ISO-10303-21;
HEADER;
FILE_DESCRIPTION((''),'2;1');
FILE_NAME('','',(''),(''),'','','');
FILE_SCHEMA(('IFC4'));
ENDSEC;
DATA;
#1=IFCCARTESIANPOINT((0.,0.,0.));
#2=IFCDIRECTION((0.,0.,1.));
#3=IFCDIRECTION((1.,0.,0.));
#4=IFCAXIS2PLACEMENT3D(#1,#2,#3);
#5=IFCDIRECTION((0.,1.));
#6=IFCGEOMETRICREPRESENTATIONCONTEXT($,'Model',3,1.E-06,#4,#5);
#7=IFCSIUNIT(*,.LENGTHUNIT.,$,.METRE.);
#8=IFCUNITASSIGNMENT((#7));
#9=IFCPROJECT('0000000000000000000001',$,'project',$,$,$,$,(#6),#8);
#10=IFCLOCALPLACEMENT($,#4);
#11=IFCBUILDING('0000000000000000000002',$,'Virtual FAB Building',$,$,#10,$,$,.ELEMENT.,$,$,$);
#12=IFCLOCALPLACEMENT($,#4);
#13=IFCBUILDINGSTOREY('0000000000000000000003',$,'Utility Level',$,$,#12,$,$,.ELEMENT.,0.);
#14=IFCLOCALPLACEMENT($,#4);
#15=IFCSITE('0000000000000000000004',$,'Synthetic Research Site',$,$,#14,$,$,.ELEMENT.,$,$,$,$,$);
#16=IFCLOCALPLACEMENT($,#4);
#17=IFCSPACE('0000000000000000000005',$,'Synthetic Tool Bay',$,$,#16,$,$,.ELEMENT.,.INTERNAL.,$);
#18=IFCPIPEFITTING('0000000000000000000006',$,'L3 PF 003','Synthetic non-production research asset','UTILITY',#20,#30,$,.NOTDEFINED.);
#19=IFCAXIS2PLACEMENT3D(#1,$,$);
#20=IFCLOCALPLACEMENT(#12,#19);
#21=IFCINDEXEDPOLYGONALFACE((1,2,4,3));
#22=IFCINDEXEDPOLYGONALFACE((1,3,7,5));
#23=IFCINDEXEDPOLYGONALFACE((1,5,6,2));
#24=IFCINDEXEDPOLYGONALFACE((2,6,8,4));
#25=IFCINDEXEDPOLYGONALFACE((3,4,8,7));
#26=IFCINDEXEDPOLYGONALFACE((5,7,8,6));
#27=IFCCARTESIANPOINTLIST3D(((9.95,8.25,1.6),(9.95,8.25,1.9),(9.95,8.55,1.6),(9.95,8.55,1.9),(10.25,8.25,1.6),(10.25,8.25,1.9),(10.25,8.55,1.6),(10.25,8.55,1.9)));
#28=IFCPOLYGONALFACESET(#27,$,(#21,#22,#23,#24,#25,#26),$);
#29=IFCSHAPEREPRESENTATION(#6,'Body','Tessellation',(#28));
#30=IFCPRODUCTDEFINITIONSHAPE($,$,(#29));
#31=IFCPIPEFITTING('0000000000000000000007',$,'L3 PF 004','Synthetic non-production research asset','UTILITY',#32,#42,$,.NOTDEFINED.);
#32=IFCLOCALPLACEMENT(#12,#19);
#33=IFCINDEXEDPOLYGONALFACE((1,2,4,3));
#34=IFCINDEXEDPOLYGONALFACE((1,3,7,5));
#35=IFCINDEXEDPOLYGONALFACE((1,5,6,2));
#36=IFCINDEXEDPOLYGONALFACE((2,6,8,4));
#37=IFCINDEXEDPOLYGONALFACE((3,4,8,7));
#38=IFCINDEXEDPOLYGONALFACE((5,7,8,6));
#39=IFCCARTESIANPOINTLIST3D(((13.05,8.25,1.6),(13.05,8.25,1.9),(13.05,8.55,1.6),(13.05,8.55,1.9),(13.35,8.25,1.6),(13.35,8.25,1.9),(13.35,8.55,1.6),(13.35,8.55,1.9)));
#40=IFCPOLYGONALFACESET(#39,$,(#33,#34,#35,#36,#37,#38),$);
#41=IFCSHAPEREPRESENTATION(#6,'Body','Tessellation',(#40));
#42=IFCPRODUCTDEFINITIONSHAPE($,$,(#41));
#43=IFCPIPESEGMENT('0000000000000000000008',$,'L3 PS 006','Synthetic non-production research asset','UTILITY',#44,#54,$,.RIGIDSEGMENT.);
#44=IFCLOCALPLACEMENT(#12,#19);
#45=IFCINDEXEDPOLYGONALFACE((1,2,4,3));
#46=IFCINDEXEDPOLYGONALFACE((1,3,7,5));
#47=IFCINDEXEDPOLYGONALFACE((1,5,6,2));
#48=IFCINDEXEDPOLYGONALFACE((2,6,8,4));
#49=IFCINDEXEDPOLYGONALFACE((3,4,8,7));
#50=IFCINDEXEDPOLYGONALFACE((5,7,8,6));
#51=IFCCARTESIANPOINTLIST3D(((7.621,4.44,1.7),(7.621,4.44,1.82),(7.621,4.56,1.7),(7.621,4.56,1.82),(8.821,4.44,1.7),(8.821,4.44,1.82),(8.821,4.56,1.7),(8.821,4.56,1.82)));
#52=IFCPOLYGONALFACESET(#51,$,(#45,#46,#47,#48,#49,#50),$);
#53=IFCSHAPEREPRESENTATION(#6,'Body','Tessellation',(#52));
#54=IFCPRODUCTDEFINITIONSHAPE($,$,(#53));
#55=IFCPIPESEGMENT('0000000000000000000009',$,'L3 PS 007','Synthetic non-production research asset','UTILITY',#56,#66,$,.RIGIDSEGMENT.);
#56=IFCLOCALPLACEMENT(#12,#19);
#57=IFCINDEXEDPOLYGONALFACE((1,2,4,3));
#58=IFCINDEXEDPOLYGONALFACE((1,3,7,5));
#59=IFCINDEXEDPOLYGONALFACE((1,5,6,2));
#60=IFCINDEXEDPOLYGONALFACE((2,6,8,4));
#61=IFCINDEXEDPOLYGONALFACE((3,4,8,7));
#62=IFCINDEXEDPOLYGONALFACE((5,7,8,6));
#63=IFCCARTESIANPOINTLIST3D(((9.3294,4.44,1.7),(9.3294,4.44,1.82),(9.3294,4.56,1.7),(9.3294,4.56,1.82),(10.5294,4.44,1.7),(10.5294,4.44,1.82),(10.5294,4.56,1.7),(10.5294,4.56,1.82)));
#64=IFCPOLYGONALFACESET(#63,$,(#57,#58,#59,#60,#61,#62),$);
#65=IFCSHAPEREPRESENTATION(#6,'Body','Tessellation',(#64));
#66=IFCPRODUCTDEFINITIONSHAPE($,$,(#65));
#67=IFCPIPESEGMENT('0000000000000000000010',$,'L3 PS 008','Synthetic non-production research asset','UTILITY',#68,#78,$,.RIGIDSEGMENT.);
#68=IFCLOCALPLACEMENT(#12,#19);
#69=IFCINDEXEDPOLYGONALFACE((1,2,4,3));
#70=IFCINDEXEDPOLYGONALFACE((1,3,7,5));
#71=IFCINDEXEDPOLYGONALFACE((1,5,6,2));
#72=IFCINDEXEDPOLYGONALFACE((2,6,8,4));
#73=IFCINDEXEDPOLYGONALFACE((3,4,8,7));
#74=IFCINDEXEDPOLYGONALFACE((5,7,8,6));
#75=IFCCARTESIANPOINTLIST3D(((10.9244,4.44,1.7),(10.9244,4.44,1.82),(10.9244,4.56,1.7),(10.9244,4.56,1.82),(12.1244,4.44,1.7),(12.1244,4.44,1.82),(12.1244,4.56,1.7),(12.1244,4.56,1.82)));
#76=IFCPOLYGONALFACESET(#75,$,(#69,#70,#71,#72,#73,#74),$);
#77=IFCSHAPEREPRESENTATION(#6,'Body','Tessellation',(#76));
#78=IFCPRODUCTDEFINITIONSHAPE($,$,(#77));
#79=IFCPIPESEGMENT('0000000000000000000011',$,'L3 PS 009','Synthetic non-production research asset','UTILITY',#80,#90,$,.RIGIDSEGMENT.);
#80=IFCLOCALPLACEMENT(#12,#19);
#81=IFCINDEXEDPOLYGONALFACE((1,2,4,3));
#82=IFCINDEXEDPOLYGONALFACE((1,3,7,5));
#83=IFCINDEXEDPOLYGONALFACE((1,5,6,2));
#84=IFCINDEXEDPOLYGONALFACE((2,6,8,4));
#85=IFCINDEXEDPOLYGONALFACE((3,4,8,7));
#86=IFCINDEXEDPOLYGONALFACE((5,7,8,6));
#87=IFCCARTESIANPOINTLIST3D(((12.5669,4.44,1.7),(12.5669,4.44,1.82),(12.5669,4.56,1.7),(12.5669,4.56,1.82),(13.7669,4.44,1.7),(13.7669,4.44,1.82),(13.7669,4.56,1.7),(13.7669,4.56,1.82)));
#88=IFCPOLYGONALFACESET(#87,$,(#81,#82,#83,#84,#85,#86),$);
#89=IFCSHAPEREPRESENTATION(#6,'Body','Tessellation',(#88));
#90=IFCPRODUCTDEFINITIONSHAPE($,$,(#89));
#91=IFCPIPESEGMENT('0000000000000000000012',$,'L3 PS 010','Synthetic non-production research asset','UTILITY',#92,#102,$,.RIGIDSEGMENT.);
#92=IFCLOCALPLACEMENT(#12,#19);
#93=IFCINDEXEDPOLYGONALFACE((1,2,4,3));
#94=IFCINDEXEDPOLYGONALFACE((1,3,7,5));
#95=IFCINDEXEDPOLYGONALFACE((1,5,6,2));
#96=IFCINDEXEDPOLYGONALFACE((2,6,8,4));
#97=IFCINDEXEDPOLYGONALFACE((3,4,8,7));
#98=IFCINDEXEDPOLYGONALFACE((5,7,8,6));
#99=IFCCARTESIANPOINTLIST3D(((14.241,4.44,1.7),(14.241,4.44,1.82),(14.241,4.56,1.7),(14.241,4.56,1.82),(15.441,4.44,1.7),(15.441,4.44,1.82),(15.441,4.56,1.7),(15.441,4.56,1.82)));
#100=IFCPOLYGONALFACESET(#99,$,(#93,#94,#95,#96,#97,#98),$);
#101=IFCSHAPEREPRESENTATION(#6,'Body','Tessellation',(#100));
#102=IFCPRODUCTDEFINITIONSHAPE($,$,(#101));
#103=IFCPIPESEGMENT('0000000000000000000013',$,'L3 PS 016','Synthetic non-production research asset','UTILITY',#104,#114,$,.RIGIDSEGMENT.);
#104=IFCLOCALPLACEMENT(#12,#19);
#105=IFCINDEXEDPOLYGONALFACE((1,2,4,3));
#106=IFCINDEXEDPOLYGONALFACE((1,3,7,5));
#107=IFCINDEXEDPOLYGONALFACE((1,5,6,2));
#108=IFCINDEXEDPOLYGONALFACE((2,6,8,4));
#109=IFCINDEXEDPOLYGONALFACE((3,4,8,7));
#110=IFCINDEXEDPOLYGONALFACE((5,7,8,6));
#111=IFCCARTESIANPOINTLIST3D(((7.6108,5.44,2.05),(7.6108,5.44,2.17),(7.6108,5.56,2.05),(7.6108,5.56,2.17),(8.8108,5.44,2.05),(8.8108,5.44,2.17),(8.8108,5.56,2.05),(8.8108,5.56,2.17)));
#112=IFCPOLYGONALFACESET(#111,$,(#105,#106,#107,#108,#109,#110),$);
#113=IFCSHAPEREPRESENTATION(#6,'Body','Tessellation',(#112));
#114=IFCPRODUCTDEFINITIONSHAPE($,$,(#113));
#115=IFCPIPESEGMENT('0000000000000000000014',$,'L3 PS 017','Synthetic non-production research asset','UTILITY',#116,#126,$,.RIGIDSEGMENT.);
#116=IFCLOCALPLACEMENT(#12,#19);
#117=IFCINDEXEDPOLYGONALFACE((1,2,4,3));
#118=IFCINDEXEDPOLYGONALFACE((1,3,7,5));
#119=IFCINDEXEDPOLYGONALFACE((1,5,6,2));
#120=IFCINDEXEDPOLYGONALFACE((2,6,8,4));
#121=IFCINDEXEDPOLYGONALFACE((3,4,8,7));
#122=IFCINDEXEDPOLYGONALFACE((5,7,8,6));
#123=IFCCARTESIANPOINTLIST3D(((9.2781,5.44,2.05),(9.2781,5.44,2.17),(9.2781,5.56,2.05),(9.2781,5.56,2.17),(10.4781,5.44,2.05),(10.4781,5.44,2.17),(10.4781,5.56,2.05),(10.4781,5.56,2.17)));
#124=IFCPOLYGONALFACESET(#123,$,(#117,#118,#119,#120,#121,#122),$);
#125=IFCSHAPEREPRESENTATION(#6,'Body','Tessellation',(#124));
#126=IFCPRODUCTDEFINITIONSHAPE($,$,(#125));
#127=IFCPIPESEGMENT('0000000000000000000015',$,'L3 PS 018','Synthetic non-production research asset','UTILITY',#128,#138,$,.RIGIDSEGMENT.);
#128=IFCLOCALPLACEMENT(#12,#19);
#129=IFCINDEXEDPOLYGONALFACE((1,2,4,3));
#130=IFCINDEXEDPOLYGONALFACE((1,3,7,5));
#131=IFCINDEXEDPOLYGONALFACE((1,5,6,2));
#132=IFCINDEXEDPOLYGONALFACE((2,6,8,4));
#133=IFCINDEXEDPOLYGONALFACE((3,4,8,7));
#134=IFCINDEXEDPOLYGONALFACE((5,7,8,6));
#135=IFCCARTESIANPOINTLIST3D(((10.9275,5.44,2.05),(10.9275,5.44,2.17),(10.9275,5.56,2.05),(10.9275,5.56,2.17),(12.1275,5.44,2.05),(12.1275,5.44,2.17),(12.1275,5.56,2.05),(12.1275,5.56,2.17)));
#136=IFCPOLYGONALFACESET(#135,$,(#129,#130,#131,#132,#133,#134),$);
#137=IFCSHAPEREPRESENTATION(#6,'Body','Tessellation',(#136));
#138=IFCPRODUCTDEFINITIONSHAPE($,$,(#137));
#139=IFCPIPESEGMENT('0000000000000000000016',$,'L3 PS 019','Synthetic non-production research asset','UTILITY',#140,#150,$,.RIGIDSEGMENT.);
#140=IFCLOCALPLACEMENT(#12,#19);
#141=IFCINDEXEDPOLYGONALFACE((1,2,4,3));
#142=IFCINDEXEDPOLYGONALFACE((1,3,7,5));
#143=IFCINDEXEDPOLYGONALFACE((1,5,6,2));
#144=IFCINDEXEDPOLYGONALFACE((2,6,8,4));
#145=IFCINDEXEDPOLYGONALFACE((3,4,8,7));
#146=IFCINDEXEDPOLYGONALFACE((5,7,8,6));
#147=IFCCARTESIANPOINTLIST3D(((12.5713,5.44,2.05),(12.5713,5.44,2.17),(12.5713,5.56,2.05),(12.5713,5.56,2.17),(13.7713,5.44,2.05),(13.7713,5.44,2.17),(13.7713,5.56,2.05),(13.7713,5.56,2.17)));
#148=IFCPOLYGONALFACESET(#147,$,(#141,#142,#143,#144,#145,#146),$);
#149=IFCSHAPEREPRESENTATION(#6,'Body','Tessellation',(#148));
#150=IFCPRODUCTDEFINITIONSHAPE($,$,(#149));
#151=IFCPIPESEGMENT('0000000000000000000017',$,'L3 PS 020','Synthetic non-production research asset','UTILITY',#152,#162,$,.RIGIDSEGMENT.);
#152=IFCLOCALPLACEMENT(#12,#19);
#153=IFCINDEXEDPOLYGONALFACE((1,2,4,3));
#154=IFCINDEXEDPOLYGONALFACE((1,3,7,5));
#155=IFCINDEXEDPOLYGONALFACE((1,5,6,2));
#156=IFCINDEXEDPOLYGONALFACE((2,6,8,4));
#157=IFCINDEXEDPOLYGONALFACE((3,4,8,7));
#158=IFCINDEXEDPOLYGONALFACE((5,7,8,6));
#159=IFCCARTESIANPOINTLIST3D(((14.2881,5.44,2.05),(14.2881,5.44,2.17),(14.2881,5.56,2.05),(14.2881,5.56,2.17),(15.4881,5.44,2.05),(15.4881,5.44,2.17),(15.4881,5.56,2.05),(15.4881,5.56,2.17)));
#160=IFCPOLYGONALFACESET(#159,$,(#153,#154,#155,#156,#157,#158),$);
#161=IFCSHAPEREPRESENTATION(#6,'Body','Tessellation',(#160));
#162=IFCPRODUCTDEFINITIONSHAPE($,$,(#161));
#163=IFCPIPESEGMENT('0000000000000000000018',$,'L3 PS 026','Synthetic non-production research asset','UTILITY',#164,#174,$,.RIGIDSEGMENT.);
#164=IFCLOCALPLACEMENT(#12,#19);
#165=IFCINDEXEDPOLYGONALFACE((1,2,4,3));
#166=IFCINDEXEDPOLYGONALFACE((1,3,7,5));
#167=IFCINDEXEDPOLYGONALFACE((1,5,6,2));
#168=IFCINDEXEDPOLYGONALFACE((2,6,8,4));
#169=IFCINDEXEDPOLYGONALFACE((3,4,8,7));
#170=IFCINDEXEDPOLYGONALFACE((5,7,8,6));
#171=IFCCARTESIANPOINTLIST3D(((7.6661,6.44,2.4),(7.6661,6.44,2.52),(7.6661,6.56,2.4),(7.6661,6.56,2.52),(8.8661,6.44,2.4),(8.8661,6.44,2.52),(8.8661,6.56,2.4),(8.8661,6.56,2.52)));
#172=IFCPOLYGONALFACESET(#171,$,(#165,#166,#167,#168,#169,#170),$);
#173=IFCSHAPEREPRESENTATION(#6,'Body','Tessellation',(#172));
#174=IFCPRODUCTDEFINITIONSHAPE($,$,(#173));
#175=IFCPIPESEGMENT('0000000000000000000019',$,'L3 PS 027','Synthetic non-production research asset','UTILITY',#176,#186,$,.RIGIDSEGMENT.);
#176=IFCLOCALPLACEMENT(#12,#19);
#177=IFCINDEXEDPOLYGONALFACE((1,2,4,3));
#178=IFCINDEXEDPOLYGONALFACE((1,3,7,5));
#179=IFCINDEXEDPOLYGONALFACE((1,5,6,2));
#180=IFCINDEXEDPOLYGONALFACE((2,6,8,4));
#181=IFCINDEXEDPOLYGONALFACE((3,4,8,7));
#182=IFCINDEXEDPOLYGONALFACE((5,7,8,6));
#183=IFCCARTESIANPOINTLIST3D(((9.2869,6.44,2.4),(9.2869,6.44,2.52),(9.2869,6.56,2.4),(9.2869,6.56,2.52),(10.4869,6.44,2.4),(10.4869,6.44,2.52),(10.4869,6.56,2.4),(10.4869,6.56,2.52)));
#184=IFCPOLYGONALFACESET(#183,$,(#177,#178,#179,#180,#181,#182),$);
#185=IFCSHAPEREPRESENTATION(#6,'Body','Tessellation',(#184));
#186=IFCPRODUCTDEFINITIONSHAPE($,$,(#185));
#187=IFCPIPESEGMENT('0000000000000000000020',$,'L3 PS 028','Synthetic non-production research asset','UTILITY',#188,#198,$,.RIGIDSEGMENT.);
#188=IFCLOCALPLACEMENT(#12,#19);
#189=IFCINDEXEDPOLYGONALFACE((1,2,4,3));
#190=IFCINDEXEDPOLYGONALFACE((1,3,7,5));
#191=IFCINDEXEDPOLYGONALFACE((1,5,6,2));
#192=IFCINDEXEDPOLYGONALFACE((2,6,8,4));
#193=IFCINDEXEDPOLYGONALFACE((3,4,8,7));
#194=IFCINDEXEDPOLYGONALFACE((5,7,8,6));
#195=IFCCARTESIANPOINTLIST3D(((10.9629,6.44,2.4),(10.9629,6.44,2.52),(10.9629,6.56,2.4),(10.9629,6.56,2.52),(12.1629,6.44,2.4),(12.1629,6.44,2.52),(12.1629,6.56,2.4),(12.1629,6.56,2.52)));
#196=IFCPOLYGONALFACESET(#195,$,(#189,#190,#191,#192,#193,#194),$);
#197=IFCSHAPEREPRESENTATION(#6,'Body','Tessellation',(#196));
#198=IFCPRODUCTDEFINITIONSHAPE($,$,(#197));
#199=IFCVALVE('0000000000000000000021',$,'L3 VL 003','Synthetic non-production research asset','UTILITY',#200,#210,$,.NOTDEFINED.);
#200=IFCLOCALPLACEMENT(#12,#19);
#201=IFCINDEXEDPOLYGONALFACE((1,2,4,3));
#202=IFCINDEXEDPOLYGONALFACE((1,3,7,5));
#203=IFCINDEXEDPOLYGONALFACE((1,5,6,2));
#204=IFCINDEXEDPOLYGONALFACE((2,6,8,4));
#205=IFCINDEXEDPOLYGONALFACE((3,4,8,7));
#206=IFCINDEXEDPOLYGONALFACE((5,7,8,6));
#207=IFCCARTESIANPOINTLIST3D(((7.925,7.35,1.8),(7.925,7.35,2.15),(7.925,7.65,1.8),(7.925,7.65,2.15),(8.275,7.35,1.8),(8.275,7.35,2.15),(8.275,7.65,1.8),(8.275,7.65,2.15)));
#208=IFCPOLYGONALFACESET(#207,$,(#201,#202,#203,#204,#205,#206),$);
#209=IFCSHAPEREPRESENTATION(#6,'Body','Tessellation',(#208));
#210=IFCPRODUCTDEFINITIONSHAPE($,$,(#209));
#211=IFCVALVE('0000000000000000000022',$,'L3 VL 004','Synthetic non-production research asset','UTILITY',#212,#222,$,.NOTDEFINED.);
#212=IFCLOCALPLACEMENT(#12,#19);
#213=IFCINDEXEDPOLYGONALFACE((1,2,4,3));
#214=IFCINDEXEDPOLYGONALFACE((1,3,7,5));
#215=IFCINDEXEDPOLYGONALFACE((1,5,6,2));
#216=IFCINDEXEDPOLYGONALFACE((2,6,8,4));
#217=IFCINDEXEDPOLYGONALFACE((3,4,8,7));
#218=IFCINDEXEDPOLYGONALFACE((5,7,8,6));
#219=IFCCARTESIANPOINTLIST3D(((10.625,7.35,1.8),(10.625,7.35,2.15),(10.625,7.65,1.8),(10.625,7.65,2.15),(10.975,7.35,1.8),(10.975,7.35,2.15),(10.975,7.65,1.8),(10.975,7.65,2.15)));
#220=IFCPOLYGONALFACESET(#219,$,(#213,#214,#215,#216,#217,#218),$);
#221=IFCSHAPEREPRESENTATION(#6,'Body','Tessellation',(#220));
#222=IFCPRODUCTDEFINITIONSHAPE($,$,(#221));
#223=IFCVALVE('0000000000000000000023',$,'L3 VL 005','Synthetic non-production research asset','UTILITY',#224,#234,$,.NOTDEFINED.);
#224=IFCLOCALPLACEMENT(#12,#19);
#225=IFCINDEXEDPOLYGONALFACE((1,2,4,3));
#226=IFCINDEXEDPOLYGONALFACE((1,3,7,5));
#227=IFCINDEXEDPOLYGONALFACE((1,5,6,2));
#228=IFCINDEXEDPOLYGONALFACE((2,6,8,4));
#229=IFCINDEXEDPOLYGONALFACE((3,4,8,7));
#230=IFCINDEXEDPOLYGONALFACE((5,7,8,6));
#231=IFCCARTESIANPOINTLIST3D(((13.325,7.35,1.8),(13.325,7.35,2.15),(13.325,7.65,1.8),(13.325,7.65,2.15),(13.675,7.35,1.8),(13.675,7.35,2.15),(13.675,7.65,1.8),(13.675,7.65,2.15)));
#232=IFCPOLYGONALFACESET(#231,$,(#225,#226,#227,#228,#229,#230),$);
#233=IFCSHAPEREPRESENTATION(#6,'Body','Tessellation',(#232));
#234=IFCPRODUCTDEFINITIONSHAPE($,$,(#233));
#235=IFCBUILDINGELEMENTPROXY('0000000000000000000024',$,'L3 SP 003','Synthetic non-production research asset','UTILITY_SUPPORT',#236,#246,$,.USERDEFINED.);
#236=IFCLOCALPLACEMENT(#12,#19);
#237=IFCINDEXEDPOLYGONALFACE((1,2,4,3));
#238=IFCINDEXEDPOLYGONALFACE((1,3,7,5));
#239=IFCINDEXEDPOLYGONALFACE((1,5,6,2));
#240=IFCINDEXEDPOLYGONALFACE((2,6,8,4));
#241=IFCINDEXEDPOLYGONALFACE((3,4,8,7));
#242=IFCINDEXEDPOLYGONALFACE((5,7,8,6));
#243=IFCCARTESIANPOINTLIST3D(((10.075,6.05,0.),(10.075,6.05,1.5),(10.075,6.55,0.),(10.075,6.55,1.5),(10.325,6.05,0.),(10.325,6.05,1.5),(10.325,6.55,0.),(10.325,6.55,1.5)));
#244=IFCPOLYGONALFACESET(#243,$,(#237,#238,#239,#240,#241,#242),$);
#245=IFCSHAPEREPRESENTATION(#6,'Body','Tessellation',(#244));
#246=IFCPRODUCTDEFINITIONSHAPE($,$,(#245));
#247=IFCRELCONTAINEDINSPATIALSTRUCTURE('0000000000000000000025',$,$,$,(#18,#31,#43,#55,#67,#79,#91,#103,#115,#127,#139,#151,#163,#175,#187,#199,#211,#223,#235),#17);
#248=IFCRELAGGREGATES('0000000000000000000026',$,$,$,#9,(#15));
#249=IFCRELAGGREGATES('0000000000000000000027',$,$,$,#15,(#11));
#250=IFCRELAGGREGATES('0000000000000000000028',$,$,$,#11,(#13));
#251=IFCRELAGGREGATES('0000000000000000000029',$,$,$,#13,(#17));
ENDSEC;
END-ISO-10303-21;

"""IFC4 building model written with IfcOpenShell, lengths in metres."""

from ifc_helpers import new_model, si_unit, direction, frame, origin_with_axes, origin_2d_with_axis, place, context, project, spatial, rectangle, extrude, element, save


model = new_model("IFC4")

# Units and contexts
model_context = context("Model", 3, precision=1e-06, world=origin_with_axes(), true_north=direction((0.0, 1.0)))
ifc_project = project(units=[si_unit("LENGTHUNIT", "METRE")], contexts=[model_context])

# Site, building, storey, space
site_placement = place(None, origin_with_axes())
site = spatial("IfcSite", under=ifc_project, at=site_placement, Name="Synthetic Research Site", CompositionType="ELEMENT")
building_placement = place(None, origin_with_axes())
building = spatial("IfcBuilding", under=site, at=building_placement, Name="Virtual FAB Building", CompositionType="ELEMENT")
storey_placement = place(None, origin_with_axes())
storey = spatial("IfcBuildingStorey", under=building, at=storey_placement, Name="Utility Level", CompositionType="ELEMENT", Elevation=0.0)
space_placement = place(None, origin_with_axes())
space = spatial("IfcSpace", under=storey, at=space_placement, Name="Synthetic Tool Bay", CompositionType="ELEMENT", PredefinedType="INTERNAL")

# Pipe fittings
for number, where, z_axis, x_axis, name in (
    (1, (10.1, 8.4, 1.6), (0.0, 0.0, 1.0), (1.0, 0.0, 0.0), "L3 PF 003"),
    (2, (13.2, 8.4, 1.6), (0.0, 0.0, 1.0), (1.0, 0.0, 0.0), "L3 PF 004"),
):
    element("IfcPipeFitting", number, at=place(None, frame(where, z_axis=z_axis, x_axis=x_axis)), inside=space, Name=name, Description="Synthetic non-production research asset", ObjectType="UTILITY", PredefinedType="NOTDEFINED", context=model_context, shape_type="SweptSolid", body=[
        extrude(rectangle(XDim=0.3, YDim=0.3, at=origin_2d_with_axis()), origin_with_axes(), (0.0, 0.0, 1.0), 0.3),
    ])

# Pipe segments
for number, where, z_axis, x_axis, name in (
    (3, (8.221, 4.5, 1.7), (0.0, 0.0, 1.0), (1.0, 0.0, 0.0), "L3 PS 006"),
    (4, (9.9294, 4.5, 1.7), (0.0, 0.0, 1.0), (1.0, 0.0, 0.0), "L3 PS 007"),
    (5, (11.5244, 4.5, 1.7), (0.0, 0.0, 1.0), (1.0, 0.0, 0.0), "L3 PS 008"),
    (6, (13.1669, 4.5, 1.7), (0.0, 0.0, 1.0), (1.0, 0.0, 0.0), "L3 PS 009"),
    (7, (14.841, 4.5, 1.7), (0.0, 0.0, 1.0), (1.0, 0.0, 0.0), "L3 PS 010"),
    (8, (8.2108, 5.5, 2.05), (0.0, 0.0, 1.0), (1.0, 0.0, 0.0), "L3 PS 016"),
    (9, (9.8781, 5.5, 2.05), (0.0, 0.0, 1.0), (1.0, 0.0, 0.0), "L3 PS 017"),
    (10, (11.5275, 5.5, 2.05), (0.0, 0.0, 1.0), (1.0, 0.0, 0.0), "L3 PS 018"),
    (11, (13.1713, 5.5, 2.05), (0.0, 0.0, 1.0), (1.0, 0.0, 0.0), "L3 PS 019"),
    (12, (14.8881, 5.5, 2.05), (0.0, 0.0, 1.0), (1.0, 0.0, 0.0), "L3 PS 020"),
    (13, (8.2661, 6.5, 2.4), (0.0, 0.0, 1.0), (1.0, 0.0, 0.0), "L3 PS 026"),
    (14, (9.8869, 6.5, 2.4), (0.0, 0.0, 1.0), (1.0, 0.0, 0.0), "L3 PS 027"),
    (15, (11.5629, 6.5, 2.4), (0.0, 0.0, 1.0), (1.0, 0.0, 0.0), "L3 PS 028"),
):
    element("IfcPipeSegment", number, at=place(None, frame(where, z_axis=z_axis, x_axis=x_axis)), inside=space, Name=name, Description="Synthetic non-production research asset", ObjectType="UTILITY", PredefinedType="RIGIDSEGMENT", context=model_context, shape_type="SweptSolid", body=[
        extrude(rectangle(XDim=1.2, YDim=0.12, at=origin_2d_with_axis()), origin_with_axes(), (0.0, 0.0, 1.0), 0.12),
    ])

# Valves
for number, where, z_axis, x_axis, name in (
    (16, (8.1, 7.5, 1.8), (0.0, 0.0, 1.0), (1.0, 0.0, 0.0), "L3 VL 003"),
    (17, (10.8, 7.5, 1.8), (0.0, 0.0, 1.0), (1.0, 0.0, 0.0), "L3 VL 004"),
    (18, (13.5, 7.5, 1.8), (0.0, 0.0, 1.0), (1.0, 0.0, 0.0), "L3 VL 005"),
):
    element("IfcValve", number, at=place(None, frame(where, z_axis=z_axis, x_axis=x_axis)), inside=space, Name=name, Description="Synthetic non-production research asset", ObjectType="UTILITY", PredefinedType="NOTDEFINED", context=model_context, shape_type="SweptSolid", body=[
        extrude(rectangle(XDim=0.35, YDim=0.3, at=origin_2d_with_axis()), origin_with_axes(), (0.0, 0.0, 1.0), 0.35),
    ])

# Building element proxy
for number, where, z_axis, x_axis, name in (
    (19, (10.2, 6.3, 0.0), (0.0, 0.0, 1.0), (1.0, 0.0, 0.0), "L3 SP 003"),
):
    element("IfcBuildingElementProxy", number, at=place(None, frame(where, z_axis=z_axis, x_axis=x_axis)), inside=space, Name=name, Description="Synthetic non-production research asset", ObjectType="UTILITY_SUPPORT", PredefinedType="USERDEFINED", context=model_context, shape_type="SweptSolid", body=[
        extrude(rectangle(XDim=0.25, YDim=0.5, at=origin_2d_with_axis()), origin_with_axes(), (0.0, 0.0, 1.0), 1.5),
    ])

save(model, "model.ifc")
